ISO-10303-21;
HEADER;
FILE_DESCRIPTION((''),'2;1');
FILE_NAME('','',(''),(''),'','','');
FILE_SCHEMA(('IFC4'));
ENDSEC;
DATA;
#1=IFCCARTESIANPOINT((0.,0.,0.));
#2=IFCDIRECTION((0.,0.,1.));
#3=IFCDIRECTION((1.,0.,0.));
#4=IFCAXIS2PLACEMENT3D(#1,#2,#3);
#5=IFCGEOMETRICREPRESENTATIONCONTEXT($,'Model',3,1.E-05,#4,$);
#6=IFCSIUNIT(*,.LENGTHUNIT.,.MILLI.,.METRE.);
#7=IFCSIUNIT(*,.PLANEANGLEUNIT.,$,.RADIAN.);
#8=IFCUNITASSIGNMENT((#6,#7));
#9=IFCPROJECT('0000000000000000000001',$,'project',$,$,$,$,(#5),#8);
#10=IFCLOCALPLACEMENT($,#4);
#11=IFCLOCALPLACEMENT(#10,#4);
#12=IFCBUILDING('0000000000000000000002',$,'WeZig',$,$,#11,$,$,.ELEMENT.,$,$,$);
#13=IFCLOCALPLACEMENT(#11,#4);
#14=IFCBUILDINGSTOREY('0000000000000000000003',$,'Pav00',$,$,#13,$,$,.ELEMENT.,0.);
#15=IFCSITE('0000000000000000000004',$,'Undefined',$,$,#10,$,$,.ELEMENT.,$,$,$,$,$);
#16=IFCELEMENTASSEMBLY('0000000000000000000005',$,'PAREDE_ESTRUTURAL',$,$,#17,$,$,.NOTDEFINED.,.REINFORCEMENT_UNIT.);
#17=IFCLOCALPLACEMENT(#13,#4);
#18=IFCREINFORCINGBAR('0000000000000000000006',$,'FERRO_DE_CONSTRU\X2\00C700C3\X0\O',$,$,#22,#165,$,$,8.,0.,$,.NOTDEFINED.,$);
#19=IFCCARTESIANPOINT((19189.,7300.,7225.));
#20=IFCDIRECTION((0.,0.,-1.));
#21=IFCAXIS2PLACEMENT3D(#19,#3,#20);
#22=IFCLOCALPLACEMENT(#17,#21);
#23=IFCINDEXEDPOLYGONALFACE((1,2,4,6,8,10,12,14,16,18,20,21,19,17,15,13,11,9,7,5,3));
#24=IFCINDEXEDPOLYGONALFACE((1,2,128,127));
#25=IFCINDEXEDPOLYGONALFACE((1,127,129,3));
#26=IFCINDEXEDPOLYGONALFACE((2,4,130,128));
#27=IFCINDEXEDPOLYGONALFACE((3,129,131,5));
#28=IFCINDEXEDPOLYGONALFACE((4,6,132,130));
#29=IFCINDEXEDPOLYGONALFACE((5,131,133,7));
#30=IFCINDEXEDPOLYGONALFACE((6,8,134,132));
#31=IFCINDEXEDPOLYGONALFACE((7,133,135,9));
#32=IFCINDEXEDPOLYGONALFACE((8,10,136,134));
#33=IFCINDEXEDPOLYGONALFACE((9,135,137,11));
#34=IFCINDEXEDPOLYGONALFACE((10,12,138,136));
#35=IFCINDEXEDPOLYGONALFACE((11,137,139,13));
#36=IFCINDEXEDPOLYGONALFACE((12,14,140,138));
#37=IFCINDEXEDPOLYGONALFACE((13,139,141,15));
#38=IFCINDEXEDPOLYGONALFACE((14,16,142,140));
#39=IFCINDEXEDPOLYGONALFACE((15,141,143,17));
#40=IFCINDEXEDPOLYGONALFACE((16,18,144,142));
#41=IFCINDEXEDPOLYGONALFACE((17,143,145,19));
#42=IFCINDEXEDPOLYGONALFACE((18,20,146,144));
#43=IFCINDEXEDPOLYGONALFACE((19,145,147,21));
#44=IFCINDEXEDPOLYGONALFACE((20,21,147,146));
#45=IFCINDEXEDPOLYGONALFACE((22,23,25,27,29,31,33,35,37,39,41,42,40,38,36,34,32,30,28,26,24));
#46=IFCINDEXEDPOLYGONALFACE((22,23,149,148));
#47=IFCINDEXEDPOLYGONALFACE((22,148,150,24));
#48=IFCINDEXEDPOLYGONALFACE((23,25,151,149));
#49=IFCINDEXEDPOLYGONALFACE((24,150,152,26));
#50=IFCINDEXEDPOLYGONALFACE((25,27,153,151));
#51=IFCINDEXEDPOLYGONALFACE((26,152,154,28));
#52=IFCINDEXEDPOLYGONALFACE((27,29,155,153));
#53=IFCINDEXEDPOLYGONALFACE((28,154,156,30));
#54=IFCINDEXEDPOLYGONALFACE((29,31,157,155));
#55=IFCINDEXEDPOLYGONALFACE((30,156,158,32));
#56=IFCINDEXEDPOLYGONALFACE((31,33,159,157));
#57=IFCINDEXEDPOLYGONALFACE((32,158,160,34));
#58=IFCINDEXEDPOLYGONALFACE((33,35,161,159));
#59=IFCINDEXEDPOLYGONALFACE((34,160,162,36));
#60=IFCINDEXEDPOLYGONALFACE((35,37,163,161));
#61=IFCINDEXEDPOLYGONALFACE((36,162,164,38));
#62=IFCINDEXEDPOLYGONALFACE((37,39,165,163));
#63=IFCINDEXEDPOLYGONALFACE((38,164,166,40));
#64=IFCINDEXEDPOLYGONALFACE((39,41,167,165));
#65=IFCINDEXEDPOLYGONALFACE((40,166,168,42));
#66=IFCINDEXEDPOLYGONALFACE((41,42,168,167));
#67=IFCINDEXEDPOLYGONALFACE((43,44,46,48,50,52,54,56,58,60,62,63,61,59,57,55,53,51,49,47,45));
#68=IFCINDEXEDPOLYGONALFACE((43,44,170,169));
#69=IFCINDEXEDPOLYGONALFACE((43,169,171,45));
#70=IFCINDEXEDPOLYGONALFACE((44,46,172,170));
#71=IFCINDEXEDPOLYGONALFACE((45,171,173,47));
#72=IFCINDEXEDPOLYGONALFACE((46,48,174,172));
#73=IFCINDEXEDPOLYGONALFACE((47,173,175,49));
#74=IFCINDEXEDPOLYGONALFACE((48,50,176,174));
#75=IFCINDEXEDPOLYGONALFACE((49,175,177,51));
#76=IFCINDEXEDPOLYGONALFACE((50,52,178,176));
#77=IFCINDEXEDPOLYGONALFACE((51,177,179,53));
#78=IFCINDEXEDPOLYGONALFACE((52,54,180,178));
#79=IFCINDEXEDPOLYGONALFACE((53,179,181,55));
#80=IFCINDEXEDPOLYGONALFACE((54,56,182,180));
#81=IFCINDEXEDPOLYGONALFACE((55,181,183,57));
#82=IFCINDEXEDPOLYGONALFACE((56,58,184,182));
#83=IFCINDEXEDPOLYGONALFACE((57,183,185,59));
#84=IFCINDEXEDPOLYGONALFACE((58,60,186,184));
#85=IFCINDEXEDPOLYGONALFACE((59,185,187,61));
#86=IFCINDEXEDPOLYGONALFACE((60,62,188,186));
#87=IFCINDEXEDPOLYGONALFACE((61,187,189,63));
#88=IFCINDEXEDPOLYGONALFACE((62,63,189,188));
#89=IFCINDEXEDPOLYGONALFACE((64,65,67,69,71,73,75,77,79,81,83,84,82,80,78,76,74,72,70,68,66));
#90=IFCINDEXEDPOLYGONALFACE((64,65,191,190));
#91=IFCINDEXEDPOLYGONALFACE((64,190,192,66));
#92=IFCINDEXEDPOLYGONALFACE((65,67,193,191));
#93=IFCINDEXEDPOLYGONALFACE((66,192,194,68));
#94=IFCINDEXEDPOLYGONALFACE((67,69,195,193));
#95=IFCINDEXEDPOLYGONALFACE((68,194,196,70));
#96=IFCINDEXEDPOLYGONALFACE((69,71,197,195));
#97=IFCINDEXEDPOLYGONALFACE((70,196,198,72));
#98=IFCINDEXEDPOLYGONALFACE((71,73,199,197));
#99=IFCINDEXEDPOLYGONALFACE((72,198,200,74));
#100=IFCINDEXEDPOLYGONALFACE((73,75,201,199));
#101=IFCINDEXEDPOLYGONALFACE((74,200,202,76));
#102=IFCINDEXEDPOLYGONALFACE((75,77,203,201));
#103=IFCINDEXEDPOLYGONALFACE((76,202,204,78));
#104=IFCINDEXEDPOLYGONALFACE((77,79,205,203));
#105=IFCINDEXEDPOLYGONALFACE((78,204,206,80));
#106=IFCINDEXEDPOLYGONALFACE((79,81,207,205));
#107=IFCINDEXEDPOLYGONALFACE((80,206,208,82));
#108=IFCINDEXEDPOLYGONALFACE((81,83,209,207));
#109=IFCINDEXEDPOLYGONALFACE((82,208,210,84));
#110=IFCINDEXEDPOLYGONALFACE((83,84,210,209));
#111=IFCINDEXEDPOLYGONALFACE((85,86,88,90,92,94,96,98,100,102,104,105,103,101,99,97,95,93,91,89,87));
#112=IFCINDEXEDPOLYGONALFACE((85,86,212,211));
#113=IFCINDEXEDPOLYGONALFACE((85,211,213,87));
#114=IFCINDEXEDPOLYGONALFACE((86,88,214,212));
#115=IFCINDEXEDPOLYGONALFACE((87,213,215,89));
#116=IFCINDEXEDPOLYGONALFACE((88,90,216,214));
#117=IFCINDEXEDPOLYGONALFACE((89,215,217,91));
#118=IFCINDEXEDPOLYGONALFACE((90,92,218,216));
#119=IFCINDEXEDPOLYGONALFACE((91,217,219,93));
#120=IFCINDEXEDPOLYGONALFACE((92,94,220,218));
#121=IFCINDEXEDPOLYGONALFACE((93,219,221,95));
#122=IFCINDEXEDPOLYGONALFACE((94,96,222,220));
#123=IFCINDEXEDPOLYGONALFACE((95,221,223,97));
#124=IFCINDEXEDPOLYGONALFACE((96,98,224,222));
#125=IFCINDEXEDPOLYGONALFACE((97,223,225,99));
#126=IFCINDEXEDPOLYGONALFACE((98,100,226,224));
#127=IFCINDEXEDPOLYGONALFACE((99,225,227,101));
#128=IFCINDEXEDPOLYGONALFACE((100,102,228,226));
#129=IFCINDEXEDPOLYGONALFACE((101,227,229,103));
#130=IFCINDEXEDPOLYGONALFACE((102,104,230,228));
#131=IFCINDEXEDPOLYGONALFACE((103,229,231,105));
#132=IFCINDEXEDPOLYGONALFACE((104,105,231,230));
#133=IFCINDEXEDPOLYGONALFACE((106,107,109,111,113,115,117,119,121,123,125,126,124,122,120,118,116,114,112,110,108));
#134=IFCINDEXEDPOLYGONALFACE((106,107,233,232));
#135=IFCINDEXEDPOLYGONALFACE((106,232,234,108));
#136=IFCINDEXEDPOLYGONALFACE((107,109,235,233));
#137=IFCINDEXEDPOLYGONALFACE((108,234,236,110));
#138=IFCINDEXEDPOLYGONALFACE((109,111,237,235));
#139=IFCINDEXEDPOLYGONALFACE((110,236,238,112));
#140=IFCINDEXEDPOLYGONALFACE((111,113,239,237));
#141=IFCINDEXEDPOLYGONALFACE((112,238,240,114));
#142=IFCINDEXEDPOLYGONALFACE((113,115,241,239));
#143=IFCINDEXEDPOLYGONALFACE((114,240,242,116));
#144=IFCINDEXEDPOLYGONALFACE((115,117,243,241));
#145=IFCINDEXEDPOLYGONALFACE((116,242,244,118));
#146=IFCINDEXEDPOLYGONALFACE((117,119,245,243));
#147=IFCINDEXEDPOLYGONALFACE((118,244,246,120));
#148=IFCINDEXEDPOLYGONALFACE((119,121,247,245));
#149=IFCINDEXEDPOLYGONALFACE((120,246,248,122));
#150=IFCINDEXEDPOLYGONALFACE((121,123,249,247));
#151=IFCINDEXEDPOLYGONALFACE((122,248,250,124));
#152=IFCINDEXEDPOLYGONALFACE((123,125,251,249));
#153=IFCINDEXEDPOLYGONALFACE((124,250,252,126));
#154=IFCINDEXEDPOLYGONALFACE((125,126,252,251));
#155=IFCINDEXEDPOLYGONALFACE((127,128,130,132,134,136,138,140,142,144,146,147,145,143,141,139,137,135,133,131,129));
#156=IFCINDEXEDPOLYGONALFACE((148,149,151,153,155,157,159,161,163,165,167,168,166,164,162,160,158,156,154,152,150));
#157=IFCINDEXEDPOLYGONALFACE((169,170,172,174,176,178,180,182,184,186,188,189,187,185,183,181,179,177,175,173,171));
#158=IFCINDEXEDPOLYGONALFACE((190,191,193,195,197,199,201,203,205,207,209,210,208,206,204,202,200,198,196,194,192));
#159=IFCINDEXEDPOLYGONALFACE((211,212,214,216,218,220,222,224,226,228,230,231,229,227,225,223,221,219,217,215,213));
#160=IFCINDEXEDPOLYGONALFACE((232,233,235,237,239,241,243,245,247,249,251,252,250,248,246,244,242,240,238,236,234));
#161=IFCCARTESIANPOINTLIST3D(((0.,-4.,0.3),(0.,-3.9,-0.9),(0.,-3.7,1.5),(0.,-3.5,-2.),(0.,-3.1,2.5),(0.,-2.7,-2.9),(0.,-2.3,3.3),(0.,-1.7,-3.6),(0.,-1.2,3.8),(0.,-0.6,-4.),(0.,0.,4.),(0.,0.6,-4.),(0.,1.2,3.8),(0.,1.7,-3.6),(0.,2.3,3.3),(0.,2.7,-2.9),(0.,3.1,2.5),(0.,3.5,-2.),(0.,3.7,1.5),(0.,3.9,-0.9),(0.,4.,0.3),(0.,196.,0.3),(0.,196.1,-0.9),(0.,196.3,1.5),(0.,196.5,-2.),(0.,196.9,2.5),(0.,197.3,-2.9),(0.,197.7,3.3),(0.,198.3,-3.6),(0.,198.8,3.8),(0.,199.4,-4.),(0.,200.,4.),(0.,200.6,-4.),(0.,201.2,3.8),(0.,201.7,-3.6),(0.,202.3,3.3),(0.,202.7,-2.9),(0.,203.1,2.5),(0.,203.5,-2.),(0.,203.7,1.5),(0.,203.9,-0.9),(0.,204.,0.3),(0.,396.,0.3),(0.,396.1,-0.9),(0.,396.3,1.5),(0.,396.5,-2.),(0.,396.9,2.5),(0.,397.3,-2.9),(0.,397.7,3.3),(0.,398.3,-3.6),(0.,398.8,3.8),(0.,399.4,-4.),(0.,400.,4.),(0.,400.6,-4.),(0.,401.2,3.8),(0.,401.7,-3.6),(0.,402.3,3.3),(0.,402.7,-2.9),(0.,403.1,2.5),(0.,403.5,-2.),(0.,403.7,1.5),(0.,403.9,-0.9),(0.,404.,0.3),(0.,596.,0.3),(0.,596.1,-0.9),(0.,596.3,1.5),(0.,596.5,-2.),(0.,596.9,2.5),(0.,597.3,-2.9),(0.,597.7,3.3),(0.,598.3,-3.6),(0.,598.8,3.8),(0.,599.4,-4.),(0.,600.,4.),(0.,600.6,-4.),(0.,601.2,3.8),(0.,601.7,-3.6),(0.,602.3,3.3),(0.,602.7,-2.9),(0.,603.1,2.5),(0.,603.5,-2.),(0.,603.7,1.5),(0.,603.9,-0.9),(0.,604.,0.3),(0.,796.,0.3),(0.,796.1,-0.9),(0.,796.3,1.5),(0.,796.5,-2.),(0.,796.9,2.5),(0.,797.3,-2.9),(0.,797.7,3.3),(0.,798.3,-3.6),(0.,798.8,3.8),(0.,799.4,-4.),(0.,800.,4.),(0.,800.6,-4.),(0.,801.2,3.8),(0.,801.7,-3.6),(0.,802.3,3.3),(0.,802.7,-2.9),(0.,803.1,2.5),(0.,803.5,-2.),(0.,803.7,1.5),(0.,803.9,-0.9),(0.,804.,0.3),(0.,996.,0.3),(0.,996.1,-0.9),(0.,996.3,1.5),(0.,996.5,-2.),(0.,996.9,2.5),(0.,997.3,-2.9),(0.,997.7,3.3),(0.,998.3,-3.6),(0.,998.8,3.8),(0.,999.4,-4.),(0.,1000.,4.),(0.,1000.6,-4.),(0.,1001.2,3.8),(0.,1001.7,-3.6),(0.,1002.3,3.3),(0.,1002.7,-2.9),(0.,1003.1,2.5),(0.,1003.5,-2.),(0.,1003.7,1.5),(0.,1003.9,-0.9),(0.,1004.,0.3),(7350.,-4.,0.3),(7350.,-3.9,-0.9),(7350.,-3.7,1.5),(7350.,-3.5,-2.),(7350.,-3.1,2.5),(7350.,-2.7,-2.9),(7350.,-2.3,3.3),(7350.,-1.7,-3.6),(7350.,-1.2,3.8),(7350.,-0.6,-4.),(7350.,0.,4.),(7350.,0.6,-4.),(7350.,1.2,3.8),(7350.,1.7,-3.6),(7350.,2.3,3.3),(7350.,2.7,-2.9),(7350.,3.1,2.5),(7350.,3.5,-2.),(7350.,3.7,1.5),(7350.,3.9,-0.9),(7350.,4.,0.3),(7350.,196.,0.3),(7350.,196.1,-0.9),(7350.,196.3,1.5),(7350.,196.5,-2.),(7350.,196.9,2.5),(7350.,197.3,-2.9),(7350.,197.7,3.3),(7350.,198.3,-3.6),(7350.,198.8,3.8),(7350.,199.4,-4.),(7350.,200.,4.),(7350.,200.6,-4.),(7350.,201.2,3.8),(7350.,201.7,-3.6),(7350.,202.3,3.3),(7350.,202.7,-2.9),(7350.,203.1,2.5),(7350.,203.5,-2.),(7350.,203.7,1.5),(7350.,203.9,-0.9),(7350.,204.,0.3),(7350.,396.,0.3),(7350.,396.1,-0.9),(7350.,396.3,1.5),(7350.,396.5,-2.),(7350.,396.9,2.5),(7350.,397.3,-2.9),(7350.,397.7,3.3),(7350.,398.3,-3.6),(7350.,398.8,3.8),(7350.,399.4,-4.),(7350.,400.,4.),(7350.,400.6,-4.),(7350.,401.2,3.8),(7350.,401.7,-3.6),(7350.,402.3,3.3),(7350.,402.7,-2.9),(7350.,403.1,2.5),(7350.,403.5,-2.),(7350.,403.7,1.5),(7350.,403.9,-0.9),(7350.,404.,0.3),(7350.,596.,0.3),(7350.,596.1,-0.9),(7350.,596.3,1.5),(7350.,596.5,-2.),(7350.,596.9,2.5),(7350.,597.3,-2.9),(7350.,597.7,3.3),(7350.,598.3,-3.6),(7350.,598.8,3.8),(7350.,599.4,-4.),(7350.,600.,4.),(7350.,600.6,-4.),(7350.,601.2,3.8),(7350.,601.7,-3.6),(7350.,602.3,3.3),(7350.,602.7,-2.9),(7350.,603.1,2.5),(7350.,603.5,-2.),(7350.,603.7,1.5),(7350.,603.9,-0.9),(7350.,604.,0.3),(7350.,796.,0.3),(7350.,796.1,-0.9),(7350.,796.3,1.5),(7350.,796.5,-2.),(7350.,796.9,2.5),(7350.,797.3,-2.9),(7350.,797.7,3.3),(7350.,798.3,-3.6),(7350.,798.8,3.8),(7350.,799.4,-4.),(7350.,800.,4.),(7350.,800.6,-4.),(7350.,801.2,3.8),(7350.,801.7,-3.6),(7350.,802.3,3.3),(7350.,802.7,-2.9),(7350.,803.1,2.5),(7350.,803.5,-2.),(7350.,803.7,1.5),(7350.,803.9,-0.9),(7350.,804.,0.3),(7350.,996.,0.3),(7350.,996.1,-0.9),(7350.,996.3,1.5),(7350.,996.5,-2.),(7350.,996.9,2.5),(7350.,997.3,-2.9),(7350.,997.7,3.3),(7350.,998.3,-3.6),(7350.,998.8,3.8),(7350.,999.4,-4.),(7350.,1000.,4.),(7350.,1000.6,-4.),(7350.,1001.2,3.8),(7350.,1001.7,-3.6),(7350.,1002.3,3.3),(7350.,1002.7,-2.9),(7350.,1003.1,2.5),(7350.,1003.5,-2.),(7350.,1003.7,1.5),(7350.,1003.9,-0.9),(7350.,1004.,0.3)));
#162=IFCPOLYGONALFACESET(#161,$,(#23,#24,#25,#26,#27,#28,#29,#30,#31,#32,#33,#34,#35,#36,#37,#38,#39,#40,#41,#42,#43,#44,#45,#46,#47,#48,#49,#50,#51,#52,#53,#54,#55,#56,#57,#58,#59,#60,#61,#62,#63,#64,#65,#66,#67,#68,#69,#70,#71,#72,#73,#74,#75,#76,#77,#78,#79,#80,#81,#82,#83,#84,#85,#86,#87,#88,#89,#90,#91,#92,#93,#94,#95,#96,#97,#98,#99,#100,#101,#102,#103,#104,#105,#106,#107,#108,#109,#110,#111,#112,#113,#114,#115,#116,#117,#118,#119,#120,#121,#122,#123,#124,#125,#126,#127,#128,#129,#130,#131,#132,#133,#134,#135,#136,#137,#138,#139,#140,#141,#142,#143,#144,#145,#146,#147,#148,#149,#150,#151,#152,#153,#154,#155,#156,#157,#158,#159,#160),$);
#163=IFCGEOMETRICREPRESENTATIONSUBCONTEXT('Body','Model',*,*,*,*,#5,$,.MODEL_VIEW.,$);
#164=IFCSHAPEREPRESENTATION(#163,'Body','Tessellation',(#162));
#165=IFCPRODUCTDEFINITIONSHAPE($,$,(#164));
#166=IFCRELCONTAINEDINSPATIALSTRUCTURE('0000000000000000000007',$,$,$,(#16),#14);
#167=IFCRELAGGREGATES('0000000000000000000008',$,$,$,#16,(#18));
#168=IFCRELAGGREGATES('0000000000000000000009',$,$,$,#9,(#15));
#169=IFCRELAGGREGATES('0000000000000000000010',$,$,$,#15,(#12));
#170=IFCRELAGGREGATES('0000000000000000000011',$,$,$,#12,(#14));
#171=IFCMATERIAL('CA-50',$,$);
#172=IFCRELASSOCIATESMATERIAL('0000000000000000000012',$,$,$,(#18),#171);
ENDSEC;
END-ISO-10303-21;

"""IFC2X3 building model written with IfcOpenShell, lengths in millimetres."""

from ifc_helpers import new_model, entity, si_unit, frame, origin_with_axes, place, context, subcontext, project, spatial, source, transform, mapped, material, element, aggregate, save


model = new_model("IFC2X3")

# Units and contexts
model_context = context("Model", 3, precision=1e-05, world=origin_with_axes())
body_context = subcontext(model_context, "Body", "Model", "MODEL_VIEW")
ifc_project = project(units=[si_unit("LENGTHUNIT", "METRE", prefix="MILLI"), si_unit("PLANEANGLEUNIT", "RADIAN")], contexts=[model_context])

# Site, building, storey
site_placement = place(None, origin_with_axes())
site = spatial("IfcSite", under=ifc_project, at=site_placement, Name="Undefined", CompositionType="ELEMENT")
building_placement = place(site_placement, origin_with_axes())
building = spatial("IfcBuilding", under=site, at=building_placement, Name="WeZig", CompositionType="ELEMENT")
storey_placement = place(building_placement, origin_with_axes())
storey = spatial("IfcBuildingStorey", under=building, at=storey_placement, Name="Pav00", CompositionType="ELEMENT", Elevation=0.0)

# Shared definitions
ifc_material_1 = material(Name="CA-50")

# Element assembly, reinforcing bar
assembly_1_placement = place(storey_placement, origin_with_axes())
assembly_1 = element("IfcElementAssembly", 1, at=assembly_1_placement, inside=storey, Name="PAREDE_ESTRUTURAL", AssemblyPlace="NOTDEFINED", PredefinedType="REINFORCEMENT_UNIT")
shared_shape_1 = source(origin_with_axes(), body_context, "Body", "AdvancedSweptSolid", [
    entity("IfcSweptDiskSolid", entity("IfcTrimmedCurve", entity("IfcLine", entity("IfcCartesianPoint", [0.0, 0.0, 0.0]), entity("IfcVector", entity("IfcDirection", [1.0, 0.0, 0.0]), 1.0)), [entity("IfcParameterValue", 0.0)], [entity("IfcParameterValue", 7350.0)], True, "PARAMETER"), 4.0, None, 0.0, 7350.0),
])
shared_shape_2 = source(origin_with_axes(), body_context, "Body", "AdvancedSweptSolid", [
    entity("IfcSweptDiskSolid", entity("IfcTrimmedCurve", entity("IfcLine", entity("IfcCartesianPoint", [0.0, 0.0, 0.0]), entity("IfcVector", entity("IfcDirection", [1.0, 0.0, 0.0]), 1.0)), [entity("IfcParameterValue", 0.0)], [entity("IfcParameterValue", 7350.0)], True, "PARAMETER"), 4.0, None, 0.0, 7350.0),
])
shared_shape_3 = source(origin_with_axes(), body_context, "Body", "AdvancedSweptSolid", [
    entity("IfcSweptDiskSolid", entity("IfcTrimmedCurve", entity("IfcLine", entity("IfcCartesianPoint", [0.0, 0.0, 0.0]), entity("IfcVector", entity("IfcDirection", [1.0, 0.0, 0.0]), 1.0)), [entity("IfcParameterValue", 0.0)], [entity("IfcParameterValue", 7350.0)], True, "PARAMETER"), 4.0, None, 0.0, 7350.0),
])
shared_shape_4 = source(origin_with_axes(), body_context, "Body", "AdvancedSweptSolid", [
    entity("IfcSweptDiskSolid", entity("IfcTrimmedCurve", entity("IfcLine", entity("IfcCartesianPoint", [0.0, 0.0, 0.0]), entity("IfcVector", entity("IfcDirection", [1.0, 0.0, 0.0]), 1.0)), [entity("IfcParameterValue", 0.0)], [entity("IfcParameterValue", 7350.0)], True, "PARAMETER"), 4.0, None, 0.0, 7350.0),
])
shared_shape_5 = source(origin_with_axes(), body_context, "Body", "AdvancedSweptSolid", [
    entity("IfcSweptDiskSolid", entity("IfcTrimmedCurve", entity("IfcLine", entity("IfcCartesianPoint", [0.0, 0.0, 0.0]), entity("IfcVector", entity("IfcDirection", [1.0, 0.0, 0.0]), 1.0)), [entity("IfcParameterValue", 0.0)], [entity("IfcParameterValue", 7350.0)], True, "PARAMETER"), 4.0, None, 0.0, 7350.0),
])
shared_shape_6 = source(origin_with_axes(), body_context, "Body", "AdvancedSweptSolid", [
    entity("IfcSweptDiskSolid", entity("IfcTrimmedCurve", entity("IfcLine", entity("IfcCartesianPoint", [0.0, 0.0, 0.0]), entity("IfcVector", entity("IfcDirection", [1.0, 0.0, 0.0]), 1.0)), [entity("IfcParameterValue", 0.0)], [entity("IfcParameterValue", 7350.0)], True, "PARAMETER"), 4.0, None, 0.0, 7350.0),
])
reinforcing_bar_1_placement = place(assembly_1_placement, frame((19189.0, 7300.0, 7225.0), z_axis=(1.0, 0.0, 0.0), x_axis=(0.0, 0.0, -1.0)))
reinforcing_bar_1 = element("IfcReinforcingBar", 2, at=reinforcing_bar_1_placement, material=ifc_material_1, Name="FERRO_DE_CONSTRUÇÃO", BarRole="NOTDEFINED", CrossSectionArea=0.0, NominalDiameter=8.0, context=body_context, shape_type="MappedRepresentation", body=[
    mapped(shared_shape_1, transform((0.0, 0.0, 0.0))),
    mapped(shared_shape_2, transform((0.0, 200.0, 0.0))),
    mapped(shared_shape_3, transform((0.0, 400.0, 0.0))),
    mapped(shared_shape_4, transform((0.0, 600.0, 0.0))),
    mapped(shared_shape_5, transform((0.0, 800.0, 0.0))),
    mapped(shared_shape_6, transform((0.0, 1000.0, 0.0))),
])
aggregate(assembly_1, [reinforcing_bar_1])

save(model, "model.ifc")
